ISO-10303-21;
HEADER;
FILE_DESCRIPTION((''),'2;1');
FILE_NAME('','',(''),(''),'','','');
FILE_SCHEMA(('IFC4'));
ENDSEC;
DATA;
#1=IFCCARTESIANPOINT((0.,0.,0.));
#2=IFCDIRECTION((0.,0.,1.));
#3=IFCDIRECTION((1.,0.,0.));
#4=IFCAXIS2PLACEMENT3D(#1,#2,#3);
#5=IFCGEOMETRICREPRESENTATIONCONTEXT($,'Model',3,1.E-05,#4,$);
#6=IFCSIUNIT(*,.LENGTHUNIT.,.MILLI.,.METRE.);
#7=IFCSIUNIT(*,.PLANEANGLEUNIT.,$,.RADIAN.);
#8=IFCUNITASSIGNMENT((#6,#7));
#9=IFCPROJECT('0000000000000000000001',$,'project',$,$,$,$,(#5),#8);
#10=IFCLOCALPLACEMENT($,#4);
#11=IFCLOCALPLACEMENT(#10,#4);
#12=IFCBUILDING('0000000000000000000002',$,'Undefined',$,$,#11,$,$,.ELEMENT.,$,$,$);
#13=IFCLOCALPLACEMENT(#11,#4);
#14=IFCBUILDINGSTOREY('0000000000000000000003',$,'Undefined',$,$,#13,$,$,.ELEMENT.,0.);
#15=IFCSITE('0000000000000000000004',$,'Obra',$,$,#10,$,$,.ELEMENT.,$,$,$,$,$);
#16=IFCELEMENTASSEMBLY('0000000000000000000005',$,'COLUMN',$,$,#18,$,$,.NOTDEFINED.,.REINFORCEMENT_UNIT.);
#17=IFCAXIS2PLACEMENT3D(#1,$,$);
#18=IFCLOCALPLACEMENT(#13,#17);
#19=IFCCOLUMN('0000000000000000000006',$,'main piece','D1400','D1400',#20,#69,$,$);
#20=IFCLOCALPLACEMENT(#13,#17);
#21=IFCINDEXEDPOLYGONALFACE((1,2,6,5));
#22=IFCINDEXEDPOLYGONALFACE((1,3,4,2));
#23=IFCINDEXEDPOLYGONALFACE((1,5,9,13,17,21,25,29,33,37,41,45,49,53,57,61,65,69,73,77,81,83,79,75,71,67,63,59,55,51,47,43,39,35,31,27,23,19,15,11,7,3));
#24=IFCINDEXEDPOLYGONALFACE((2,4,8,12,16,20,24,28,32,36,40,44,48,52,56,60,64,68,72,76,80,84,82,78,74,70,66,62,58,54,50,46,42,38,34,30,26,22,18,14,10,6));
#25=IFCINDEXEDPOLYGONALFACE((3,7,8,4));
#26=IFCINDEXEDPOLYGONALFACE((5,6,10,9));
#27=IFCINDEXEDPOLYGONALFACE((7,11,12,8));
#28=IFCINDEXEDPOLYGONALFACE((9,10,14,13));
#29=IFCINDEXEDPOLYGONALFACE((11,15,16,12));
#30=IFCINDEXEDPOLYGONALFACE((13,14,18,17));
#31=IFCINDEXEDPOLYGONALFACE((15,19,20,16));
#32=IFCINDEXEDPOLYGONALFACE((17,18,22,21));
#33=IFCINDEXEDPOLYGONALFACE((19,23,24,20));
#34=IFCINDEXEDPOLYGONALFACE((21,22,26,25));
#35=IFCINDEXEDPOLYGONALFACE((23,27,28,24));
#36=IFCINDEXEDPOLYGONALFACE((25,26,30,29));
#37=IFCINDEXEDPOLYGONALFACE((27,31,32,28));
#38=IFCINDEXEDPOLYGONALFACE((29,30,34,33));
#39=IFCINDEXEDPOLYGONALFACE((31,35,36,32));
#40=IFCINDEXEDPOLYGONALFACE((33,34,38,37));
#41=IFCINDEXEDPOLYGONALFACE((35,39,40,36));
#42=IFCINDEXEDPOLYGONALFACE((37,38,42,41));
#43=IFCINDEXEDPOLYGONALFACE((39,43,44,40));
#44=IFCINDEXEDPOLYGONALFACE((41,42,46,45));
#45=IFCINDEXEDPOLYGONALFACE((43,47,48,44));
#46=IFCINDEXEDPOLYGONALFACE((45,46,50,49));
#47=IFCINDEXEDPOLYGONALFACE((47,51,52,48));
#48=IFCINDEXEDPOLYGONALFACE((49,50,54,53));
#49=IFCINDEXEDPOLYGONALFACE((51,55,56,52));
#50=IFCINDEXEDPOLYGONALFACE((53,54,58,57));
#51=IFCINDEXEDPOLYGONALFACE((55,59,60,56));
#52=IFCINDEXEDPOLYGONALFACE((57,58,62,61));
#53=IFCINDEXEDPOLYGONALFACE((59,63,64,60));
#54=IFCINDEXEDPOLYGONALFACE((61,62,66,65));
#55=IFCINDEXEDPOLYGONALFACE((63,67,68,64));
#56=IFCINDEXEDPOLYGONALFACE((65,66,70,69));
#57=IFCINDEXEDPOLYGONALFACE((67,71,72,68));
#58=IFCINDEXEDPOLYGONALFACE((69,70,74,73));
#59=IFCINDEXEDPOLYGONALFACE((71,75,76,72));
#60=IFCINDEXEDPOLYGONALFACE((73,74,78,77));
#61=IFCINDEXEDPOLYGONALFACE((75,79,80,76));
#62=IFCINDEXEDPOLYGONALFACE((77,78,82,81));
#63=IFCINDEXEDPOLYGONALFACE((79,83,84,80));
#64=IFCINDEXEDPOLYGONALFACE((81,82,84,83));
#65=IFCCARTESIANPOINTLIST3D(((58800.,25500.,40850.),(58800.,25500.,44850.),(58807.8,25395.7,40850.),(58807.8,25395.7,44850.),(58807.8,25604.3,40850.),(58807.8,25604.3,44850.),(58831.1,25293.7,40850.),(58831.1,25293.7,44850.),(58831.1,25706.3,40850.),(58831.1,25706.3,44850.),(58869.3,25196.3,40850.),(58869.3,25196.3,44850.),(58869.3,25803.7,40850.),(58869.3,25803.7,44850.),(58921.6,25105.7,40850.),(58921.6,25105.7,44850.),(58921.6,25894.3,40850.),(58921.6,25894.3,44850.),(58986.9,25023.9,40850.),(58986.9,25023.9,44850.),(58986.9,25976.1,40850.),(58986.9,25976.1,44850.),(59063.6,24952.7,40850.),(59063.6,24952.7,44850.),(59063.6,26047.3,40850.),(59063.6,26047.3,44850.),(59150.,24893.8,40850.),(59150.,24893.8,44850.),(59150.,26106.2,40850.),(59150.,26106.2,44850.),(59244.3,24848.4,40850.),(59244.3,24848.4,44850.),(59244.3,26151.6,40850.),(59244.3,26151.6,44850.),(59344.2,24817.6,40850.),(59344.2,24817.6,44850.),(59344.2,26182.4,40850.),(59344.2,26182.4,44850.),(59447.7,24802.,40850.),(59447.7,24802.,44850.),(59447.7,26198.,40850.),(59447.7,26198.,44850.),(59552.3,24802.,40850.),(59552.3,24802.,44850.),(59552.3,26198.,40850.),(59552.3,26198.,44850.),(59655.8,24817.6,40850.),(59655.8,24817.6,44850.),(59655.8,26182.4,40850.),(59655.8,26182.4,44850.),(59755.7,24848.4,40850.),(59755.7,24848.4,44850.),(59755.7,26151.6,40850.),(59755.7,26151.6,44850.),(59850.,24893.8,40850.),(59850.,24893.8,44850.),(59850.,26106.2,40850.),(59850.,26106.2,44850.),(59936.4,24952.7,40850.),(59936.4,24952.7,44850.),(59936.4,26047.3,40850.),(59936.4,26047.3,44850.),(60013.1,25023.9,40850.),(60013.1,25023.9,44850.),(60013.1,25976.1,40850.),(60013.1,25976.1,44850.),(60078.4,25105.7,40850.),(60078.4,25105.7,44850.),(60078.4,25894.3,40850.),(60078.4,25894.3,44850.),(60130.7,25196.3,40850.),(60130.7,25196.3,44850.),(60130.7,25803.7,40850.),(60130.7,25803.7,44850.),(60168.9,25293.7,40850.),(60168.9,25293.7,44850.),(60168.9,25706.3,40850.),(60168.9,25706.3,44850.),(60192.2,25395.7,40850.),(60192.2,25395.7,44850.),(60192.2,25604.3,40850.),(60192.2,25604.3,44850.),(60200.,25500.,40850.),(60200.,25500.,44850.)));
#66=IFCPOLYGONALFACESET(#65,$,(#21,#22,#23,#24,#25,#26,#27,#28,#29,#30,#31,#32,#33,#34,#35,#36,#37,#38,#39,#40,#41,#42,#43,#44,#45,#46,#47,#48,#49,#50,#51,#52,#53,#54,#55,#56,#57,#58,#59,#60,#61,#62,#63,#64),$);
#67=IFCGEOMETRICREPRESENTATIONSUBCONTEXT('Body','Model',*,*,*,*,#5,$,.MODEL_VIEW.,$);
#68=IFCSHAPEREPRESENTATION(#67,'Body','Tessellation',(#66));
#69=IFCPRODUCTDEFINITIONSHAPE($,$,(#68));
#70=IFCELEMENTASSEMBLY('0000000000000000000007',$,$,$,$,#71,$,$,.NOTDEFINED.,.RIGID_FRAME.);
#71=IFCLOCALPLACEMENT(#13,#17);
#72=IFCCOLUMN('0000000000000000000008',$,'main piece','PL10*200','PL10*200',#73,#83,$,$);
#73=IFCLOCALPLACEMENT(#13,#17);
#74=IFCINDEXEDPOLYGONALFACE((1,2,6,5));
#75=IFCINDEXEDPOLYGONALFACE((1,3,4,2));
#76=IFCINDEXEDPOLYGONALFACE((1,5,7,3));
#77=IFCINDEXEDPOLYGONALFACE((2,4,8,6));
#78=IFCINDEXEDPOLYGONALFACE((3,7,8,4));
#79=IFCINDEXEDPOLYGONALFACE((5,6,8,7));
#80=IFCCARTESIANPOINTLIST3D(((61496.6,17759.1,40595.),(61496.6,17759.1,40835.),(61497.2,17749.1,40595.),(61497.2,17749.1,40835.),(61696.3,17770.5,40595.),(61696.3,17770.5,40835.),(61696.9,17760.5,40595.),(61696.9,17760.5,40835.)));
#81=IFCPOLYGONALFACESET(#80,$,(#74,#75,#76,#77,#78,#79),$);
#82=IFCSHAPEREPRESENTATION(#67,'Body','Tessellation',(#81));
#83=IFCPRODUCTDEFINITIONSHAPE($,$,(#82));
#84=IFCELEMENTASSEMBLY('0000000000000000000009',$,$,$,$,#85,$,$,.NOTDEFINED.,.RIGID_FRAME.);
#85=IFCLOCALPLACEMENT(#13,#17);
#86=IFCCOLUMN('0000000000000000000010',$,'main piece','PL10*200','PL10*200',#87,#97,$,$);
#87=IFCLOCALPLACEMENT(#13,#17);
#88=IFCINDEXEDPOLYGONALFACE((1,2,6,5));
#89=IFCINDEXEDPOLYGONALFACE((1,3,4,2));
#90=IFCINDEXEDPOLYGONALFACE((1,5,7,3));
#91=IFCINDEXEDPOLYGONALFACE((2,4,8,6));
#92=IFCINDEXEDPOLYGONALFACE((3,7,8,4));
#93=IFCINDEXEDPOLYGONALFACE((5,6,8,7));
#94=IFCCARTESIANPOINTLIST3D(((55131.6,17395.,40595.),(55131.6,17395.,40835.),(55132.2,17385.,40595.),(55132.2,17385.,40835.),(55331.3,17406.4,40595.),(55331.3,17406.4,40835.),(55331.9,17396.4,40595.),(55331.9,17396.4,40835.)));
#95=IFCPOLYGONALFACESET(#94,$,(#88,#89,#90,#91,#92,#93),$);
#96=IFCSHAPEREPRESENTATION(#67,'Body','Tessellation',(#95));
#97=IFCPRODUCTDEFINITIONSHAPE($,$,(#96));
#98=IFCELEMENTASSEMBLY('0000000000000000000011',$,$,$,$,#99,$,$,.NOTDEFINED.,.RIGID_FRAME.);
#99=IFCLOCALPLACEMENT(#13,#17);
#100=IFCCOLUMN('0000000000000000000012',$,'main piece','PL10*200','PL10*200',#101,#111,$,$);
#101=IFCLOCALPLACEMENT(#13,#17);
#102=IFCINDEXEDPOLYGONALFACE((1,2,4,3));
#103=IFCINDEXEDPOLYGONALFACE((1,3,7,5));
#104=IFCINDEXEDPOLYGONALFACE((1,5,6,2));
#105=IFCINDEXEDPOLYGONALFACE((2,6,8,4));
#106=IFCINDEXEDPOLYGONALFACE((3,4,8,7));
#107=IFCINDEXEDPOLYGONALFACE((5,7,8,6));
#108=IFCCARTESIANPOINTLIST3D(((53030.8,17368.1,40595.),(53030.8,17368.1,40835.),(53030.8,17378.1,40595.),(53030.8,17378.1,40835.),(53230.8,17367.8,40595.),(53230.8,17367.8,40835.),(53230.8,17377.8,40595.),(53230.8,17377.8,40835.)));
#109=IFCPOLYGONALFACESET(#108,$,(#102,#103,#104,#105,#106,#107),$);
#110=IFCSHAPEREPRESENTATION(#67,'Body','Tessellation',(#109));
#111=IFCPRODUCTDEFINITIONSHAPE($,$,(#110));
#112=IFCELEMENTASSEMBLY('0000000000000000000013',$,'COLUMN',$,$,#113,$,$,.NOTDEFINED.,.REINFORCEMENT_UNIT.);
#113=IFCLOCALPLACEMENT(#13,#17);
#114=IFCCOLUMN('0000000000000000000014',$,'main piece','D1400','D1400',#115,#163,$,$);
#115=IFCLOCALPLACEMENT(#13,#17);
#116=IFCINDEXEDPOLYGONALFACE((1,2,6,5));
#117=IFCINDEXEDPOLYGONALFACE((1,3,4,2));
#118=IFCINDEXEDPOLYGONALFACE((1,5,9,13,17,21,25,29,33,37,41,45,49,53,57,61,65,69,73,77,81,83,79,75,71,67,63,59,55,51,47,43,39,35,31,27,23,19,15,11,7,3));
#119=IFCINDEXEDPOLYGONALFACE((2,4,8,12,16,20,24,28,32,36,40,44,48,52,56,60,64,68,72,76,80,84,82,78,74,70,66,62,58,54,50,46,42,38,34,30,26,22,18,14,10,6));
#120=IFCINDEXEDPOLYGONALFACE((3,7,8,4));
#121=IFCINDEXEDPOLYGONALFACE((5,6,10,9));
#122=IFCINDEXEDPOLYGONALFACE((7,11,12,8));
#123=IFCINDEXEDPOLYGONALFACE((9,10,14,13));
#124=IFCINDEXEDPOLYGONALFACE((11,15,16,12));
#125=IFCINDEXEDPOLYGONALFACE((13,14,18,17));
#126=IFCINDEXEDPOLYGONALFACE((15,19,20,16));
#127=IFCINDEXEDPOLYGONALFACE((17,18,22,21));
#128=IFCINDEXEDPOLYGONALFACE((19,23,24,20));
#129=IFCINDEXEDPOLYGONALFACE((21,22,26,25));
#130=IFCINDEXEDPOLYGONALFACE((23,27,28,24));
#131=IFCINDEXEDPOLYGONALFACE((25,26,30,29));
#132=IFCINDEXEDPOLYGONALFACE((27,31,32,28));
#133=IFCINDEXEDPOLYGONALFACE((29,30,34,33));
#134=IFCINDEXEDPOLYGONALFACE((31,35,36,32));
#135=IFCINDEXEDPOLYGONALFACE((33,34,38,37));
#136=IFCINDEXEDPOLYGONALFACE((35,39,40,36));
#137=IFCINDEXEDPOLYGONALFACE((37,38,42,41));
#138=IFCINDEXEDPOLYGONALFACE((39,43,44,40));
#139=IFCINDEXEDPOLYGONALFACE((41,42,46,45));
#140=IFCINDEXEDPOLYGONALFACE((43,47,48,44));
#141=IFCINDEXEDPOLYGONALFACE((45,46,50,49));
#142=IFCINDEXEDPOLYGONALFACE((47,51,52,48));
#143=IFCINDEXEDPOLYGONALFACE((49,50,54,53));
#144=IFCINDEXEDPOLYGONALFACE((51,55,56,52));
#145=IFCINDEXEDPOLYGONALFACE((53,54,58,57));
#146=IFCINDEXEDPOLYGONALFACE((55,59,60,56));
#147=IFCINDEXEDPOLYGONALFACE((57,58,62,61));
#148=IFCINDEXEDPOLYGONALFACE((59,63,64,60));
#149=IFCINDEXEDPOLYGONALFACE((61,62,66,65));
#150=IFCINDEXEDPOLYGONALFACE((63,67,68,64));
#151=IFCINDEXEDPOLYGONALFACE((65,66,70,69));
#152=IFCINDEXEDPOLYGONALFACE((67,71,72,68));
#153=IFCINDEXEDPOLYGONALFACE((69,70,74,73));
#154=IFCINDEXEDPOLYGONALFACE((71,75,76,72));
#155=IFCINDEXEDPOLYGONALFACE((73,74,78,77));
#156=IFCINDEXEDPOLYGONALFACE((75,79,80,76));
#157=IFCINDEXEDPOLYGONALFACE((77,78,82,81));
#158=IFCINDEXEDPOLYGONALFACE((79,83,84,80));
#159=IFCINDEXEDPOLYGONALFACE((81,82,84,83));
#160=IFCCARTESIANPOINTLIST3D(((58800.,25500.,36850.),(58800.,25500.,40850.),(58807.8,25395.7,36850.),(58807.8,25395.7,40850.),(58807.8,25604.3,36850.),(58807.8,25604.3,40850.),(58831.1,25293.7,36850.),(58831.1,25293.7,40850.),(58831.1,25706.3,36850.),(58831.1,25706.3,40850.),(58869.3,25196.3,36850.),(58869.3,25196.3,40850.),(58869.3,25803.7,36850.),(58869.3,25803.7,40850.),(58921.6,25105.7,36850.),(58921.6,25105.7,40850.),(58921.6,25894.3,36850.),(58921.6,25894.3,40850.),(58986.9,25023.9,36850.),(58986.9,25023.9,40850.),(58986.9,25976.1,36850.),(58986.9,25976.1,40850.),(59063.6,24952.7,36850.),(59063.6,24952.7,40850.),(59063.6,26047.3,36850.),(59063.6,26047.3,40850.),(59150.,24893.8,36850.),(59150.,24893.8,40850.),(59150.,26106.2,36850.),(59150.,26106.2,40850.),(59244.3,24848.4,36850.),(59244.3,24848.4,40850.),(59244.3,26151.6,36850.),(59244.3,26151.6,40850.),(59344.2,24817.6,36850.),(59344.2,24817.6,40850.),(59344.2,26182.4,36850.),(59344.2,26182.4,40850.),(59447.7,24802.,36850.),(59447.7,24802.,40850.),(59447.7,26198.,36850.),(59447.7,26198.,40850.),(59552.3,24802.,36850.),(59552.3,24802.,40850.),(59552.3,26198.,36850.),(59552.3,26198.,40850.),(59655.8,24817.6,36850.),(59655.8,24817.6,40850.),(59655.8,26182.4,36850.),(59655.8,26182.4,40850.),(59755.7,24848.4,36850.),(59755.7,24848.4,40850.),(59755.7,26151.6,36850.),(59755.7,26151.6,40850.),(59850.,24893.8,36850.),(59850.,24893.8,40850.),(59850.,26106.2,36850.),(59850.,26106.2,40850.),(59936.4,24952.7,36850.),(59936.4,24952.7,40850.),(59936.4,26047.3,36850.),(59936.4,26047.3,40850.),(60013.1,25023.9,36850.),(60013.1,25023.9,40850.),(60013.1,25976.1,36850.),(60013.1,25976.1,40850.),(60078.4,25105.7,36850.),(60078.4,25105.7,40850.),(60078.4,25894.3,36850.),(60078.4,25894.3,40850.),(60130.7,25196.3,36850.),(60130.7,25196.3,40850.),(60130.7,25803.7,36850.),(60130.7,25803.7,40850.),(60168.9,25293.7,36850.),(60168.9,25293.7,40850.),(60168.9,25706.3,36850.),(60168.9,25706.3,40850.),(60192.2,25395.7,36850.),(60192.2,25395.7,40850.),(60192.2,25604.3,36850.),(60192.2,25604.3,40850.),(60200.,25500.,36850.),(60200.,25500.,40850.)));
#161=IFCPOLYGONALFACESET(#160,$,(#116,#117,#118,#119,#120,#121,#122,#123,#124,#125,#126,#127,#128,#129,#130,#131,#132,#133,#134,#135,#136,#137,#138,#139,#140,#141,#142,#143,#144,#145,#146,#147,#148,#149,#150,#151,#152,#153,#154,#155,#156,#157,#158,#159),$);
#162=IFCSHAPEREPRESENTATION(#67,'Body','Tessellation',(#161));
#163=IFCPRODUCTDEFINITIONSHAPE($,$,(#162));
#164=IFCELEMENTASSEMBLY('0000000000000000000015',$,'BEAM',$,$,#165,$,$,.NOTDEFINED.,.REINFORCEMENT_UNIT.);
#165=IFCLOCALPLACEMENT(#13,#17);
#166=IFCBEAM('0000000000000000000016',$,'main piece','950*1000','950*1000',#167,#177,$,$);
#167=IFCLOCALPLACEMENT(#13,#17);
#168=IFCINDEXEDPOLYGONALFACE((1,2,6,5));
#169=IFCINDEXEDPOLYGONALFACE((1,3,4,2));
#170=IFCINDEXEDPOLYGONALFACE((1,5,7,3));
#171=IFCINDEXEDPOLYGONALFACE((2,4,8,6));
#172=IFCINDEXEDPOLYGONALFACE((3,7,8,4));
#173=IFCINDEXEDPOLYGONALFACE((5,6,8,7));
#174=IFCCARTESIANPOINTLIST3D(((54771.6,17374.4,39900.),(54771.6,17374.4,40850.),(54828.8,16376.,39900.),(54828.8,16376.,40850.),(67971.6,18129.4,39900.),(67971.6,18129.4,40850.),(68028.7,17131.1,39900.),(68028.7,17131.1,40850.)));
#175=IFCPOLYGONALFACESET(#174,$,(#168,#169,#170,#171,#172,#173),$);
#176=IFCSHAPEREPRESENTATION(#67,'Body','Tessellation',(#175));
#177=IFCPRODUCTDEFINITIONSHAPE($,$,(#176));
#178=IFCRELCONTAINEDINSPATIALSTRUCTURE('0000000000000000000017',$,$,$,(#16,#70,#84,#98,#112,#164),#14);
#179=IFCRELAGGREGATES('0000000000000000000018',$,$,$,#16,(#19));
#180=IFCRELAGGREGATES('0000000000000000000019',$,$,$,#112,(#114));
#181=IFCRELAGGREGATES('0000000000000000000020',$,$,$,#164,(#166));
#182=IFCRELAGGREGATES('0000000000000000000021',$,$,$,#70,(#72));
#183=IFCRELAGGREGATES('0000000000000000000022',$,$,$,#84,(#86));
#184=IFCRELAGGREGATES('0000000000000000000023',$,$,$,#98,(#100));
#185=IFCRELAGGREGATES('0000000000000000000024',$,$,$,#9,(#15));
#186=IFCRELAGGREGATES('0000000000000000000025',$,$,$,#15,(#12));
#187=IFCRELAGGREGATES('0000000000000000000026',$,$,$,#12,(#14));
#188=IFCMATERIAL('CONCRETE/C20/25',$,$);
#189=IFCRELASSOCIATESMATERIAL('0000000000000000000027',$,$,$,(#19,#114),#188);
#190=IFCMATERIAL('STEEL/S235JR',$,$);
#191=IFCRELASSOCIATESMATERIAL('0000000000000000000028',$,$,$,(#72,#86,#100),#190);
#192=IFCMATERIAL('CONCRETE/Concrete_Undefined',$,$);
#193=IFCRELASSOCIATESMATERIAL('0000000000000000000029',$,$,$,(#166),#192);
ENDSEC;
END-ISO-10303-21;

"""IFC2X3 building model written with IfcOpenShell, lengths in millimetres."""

from ifc_helpers import new_model, si_unit, frame, origin_with_axes, origin_2d_with_axis, place, context, subcontext, project, spatial, rectangle, circle, extrude, material, element, aggregate, save


model = new_model("IFC2X3")

# Units and contexts
model_context = context("Model", 3, precision=1e-05, world=origin_with_axes())
body_context = subcontext(model_context, "Body", "Model", "MODEL_VIEW")
ifc_project = project(units=[si_unit("LENGTHUNIT", "METRE", prefix="MILLI"), si_unit("PLANEANGLEUNIT", "RADIAN")], contexts=[model_context])

# Site, building, storey
site_placement = place(None, origin_with_axes())
site = spatial("IfcSite", under=ifc_project, at=site_placement, Name="Obra", CompositionType="ELEMENT")
building_placement = place(site_placement, origin_with_axes())
building = spatial("IfcBuilding", under=site, at=building_placement, Name="Undefined", CompositionType="ELEMENT")
storey_placement = place(building_placement, origin_with_axes())
storey = spatial("IfcBuildingStorey", under=building, at=storey_placement, Name="Undefined", CompositionType="ELEMENT", Elevation=0.0)

# Element assemblies, columns
assembly_1_placement = place(storey_placement, origin_with_axes())
assembly_1 = element("IfcElementAssembly", 1, at=assembly_1_placement, inside=storey, Name="COLUMN", AssemblyPlace="NOTDEFINED", PredefinedType="REINFORCEMENT_UNIT")
ifc_material_1 = material(Name="CONCRETE/C20/25")
column_1_placement = place(assembly_1_placement, frame((59500.0, 25500.0, 40850.0), z_axis=(0.0, 0.0, 1.0), x_axis=(0.0, 1.0, 0.0)))
column_1 = element("IfcColumn", 2, at=column_1_placement, material=ifc_material_1, Name="main piece", Description="D1400", ObjectType="D1400", context=body_context, shape_type="SweptSolid", body=[
    extrude(circle(Radius=700.0, at=origin_2d_with_axis()), frame((0.0, 0.0, 4000.0), z_axis=(0.0, 0.0, -1.0), x_axis=(0.0, 1.0, 0.0)), (0.0, 0.0, 1.0), 4000.0),
])
aggregate(assembly_1, [column_1])
assembly_2_placement = place(storey_placement, origin_with_axes())
assembly_2 = element("IfcElementAssembly", 3, at=assembly_2_placement, inside=storey, AssemblyPlace="NOTDEFINED", PredefinedType="RIGID_FRAME")
ifc_material_2 = material(Name="STEEL/S235JR")
column_2_placement = place(assembly_2_placement, frame((61596.7, 17759.8, 40595.0), z_axis=(0.0, 0.0, 1.0), x_axis=(0.998368, 0.057107, 0.0)))
column_2 = element("IfcColumn", 4, at=column_2_placement, material=ifc_material_2, Name="main piece", Description="PL10*200", ObjectType="PL10*200", context=body_context, shape_type="SweptSolid", body=[
    extrude(rectangle(XDim=10.0, YDim=200.0, at=origin_2d_with_axis()), frame((0.0, 0.0, 240.0), z_axis=(0.0, 0.0, -1.0), x_axis=(0.0, 1.0, 0.0)), (0.0, 0.0, 1.0), 240.0),
])
assembly_3_placement = place(storey_placement, origin_with_axes())
assembly_3 = element("IfcElementAssembly", 5, at=assembly_3_placement, inside=storey, AssemblyPlace="NOTDEFINED", PredefinedType="RIGID_FRAME")
column_3_placement = place(assembly_3_placement, frame((55231.7, 17395.7, 40595.0), z_axis=(0.0, 0.0, 1.0), x_axis=(0.998368, 0.057107, 0.0)))
column_3 = element("IfcColumn", 6, at=column_3_placement, material=ifc_material_2, Name="main piece", Description="PL10*200", ObjectType="PL10*200", context=body_context, shape_type="SweptSolid", body=[
    extrude(rectangle(XDim=10.0, YDim=200.0, at=origin_2d_with_axis()), frame((0.0, 0.0, 240.0), z_axis=(0.0, 0.0, -1.0), x_axis=(0.0, 1.0, 0.0)), (0.0, 0.0, 1.0), 240.0),
])
assembly_4_placement = place(storey_placement, origin_with_axes())
assembly_4 = element("IfcElementAssembly", 7, at=assembly_4_placement, inside=storey, AssemblyPlace="NOTDEFINED", PredefinedType="RIGID_FRAME")
column_4_placement = place(assembly_4_placement, frame((53130.8, 17373.0, 40595.0), z_axis=(0.0, 0.0, 1.0), x_axis=(0.999999, -0.001649, 0.0)))
column_4 = element("IfcColumn", 8, at=column_4_placement, material=ifc_material_2, Name="main piece", Description="PL10*200", ObjectType="PL10*200", context=body_context, shape_type="SweptSolid", body=[
    extrude(rectangle(XDim=10.0, YDim=200.0, at=origin_2d_with_axis()), frame((0.0, 0.0, 240.0), z_axis=(0.0, 0.0, -1.0), x_axis=(0.0, 1.0, 0.0)), (0.0, 0.0, 1.0), 240.0),
])
assembly_5_placement = place(storey_placement, origin_with_axes())
assembly_5 = element("IfcElementAssembly", 9, at=assembly_5_placement, inside=storey, Name="COLUMN", AssemblyPlace="NOTDEFINED", PredefinedType="REINFORCEMENT_UNIT")
column_5_placement = place(assembly_5_placement, frame((59500.0, 25500.0, 36850.0), z_axis=(0.0, 0.0, 1.0), x_axis=(0.0, 1.0, 0.0)))
column_5 = element("IfcColumn", 10, at=column_5_placement, material=ifc_material_1, Name="main piece", Description="D1400", ObjectType="D1400", context=body_context, shape_type="SweptSolid", body=[
    extrude(circle(Radius=700.0, at=origin_2d_with_axis()), frame((0.0, 0.0, 4000.0), z_axis=(0.0, 0.0, -1.0), x_axis=(0.0, 1.0, 0.0)), (0.0, 0.0, 1.0), 4000.0),
])
aggregate(assembly_5, [column_5])

# Element assembly, beam
assembly_6_placement = place(storey_placement, origin_with_axes())
assembly_6 = element("IfcElementAssembly", 11, at=assembly_6_placement, inside=storey, Name="BEAM", AssemblyPlace="NOTDEFINED", PredefinedType="REINFORCEMENT_UNIT")
ifc_material_3 = material(Name="CONCRETE/Concrete_Undefined")
beam_1_placement = place(assembly_6_placement, frame((54800.2, 16875.2, 40375.0), z_axis=(0.0, 0.0, 1.0), x_axis=(0.998368, 0.057107, 0.0)))
beam_1 = element("IfcBeam", 12, at=beam_1_placement, material=ifc_material_3, Name="main piece", Description="950*1000", ObjectType="950*1000", context=body_context, shape_type="SweptSolid", body=[
    extrude(rectangle(XDim=1000.0, YDim=950.0, at=origin_2d_with_axis()), frame((13221.6, 0.0, 0.0), z_axis=(-1.0, 0.0, 0.0), x_axis=(0.0, -1.0, 0.0)), (0.0, 0.0, 1.0), 13221.6),
])
aggregate(assembly_6, [beam_1])

aggregate(assembly_2, [column_2])
aggregate(assembly_3, [column_3])
aggregate(assembly_4, [column_4])

save(model, "model.ifc")
